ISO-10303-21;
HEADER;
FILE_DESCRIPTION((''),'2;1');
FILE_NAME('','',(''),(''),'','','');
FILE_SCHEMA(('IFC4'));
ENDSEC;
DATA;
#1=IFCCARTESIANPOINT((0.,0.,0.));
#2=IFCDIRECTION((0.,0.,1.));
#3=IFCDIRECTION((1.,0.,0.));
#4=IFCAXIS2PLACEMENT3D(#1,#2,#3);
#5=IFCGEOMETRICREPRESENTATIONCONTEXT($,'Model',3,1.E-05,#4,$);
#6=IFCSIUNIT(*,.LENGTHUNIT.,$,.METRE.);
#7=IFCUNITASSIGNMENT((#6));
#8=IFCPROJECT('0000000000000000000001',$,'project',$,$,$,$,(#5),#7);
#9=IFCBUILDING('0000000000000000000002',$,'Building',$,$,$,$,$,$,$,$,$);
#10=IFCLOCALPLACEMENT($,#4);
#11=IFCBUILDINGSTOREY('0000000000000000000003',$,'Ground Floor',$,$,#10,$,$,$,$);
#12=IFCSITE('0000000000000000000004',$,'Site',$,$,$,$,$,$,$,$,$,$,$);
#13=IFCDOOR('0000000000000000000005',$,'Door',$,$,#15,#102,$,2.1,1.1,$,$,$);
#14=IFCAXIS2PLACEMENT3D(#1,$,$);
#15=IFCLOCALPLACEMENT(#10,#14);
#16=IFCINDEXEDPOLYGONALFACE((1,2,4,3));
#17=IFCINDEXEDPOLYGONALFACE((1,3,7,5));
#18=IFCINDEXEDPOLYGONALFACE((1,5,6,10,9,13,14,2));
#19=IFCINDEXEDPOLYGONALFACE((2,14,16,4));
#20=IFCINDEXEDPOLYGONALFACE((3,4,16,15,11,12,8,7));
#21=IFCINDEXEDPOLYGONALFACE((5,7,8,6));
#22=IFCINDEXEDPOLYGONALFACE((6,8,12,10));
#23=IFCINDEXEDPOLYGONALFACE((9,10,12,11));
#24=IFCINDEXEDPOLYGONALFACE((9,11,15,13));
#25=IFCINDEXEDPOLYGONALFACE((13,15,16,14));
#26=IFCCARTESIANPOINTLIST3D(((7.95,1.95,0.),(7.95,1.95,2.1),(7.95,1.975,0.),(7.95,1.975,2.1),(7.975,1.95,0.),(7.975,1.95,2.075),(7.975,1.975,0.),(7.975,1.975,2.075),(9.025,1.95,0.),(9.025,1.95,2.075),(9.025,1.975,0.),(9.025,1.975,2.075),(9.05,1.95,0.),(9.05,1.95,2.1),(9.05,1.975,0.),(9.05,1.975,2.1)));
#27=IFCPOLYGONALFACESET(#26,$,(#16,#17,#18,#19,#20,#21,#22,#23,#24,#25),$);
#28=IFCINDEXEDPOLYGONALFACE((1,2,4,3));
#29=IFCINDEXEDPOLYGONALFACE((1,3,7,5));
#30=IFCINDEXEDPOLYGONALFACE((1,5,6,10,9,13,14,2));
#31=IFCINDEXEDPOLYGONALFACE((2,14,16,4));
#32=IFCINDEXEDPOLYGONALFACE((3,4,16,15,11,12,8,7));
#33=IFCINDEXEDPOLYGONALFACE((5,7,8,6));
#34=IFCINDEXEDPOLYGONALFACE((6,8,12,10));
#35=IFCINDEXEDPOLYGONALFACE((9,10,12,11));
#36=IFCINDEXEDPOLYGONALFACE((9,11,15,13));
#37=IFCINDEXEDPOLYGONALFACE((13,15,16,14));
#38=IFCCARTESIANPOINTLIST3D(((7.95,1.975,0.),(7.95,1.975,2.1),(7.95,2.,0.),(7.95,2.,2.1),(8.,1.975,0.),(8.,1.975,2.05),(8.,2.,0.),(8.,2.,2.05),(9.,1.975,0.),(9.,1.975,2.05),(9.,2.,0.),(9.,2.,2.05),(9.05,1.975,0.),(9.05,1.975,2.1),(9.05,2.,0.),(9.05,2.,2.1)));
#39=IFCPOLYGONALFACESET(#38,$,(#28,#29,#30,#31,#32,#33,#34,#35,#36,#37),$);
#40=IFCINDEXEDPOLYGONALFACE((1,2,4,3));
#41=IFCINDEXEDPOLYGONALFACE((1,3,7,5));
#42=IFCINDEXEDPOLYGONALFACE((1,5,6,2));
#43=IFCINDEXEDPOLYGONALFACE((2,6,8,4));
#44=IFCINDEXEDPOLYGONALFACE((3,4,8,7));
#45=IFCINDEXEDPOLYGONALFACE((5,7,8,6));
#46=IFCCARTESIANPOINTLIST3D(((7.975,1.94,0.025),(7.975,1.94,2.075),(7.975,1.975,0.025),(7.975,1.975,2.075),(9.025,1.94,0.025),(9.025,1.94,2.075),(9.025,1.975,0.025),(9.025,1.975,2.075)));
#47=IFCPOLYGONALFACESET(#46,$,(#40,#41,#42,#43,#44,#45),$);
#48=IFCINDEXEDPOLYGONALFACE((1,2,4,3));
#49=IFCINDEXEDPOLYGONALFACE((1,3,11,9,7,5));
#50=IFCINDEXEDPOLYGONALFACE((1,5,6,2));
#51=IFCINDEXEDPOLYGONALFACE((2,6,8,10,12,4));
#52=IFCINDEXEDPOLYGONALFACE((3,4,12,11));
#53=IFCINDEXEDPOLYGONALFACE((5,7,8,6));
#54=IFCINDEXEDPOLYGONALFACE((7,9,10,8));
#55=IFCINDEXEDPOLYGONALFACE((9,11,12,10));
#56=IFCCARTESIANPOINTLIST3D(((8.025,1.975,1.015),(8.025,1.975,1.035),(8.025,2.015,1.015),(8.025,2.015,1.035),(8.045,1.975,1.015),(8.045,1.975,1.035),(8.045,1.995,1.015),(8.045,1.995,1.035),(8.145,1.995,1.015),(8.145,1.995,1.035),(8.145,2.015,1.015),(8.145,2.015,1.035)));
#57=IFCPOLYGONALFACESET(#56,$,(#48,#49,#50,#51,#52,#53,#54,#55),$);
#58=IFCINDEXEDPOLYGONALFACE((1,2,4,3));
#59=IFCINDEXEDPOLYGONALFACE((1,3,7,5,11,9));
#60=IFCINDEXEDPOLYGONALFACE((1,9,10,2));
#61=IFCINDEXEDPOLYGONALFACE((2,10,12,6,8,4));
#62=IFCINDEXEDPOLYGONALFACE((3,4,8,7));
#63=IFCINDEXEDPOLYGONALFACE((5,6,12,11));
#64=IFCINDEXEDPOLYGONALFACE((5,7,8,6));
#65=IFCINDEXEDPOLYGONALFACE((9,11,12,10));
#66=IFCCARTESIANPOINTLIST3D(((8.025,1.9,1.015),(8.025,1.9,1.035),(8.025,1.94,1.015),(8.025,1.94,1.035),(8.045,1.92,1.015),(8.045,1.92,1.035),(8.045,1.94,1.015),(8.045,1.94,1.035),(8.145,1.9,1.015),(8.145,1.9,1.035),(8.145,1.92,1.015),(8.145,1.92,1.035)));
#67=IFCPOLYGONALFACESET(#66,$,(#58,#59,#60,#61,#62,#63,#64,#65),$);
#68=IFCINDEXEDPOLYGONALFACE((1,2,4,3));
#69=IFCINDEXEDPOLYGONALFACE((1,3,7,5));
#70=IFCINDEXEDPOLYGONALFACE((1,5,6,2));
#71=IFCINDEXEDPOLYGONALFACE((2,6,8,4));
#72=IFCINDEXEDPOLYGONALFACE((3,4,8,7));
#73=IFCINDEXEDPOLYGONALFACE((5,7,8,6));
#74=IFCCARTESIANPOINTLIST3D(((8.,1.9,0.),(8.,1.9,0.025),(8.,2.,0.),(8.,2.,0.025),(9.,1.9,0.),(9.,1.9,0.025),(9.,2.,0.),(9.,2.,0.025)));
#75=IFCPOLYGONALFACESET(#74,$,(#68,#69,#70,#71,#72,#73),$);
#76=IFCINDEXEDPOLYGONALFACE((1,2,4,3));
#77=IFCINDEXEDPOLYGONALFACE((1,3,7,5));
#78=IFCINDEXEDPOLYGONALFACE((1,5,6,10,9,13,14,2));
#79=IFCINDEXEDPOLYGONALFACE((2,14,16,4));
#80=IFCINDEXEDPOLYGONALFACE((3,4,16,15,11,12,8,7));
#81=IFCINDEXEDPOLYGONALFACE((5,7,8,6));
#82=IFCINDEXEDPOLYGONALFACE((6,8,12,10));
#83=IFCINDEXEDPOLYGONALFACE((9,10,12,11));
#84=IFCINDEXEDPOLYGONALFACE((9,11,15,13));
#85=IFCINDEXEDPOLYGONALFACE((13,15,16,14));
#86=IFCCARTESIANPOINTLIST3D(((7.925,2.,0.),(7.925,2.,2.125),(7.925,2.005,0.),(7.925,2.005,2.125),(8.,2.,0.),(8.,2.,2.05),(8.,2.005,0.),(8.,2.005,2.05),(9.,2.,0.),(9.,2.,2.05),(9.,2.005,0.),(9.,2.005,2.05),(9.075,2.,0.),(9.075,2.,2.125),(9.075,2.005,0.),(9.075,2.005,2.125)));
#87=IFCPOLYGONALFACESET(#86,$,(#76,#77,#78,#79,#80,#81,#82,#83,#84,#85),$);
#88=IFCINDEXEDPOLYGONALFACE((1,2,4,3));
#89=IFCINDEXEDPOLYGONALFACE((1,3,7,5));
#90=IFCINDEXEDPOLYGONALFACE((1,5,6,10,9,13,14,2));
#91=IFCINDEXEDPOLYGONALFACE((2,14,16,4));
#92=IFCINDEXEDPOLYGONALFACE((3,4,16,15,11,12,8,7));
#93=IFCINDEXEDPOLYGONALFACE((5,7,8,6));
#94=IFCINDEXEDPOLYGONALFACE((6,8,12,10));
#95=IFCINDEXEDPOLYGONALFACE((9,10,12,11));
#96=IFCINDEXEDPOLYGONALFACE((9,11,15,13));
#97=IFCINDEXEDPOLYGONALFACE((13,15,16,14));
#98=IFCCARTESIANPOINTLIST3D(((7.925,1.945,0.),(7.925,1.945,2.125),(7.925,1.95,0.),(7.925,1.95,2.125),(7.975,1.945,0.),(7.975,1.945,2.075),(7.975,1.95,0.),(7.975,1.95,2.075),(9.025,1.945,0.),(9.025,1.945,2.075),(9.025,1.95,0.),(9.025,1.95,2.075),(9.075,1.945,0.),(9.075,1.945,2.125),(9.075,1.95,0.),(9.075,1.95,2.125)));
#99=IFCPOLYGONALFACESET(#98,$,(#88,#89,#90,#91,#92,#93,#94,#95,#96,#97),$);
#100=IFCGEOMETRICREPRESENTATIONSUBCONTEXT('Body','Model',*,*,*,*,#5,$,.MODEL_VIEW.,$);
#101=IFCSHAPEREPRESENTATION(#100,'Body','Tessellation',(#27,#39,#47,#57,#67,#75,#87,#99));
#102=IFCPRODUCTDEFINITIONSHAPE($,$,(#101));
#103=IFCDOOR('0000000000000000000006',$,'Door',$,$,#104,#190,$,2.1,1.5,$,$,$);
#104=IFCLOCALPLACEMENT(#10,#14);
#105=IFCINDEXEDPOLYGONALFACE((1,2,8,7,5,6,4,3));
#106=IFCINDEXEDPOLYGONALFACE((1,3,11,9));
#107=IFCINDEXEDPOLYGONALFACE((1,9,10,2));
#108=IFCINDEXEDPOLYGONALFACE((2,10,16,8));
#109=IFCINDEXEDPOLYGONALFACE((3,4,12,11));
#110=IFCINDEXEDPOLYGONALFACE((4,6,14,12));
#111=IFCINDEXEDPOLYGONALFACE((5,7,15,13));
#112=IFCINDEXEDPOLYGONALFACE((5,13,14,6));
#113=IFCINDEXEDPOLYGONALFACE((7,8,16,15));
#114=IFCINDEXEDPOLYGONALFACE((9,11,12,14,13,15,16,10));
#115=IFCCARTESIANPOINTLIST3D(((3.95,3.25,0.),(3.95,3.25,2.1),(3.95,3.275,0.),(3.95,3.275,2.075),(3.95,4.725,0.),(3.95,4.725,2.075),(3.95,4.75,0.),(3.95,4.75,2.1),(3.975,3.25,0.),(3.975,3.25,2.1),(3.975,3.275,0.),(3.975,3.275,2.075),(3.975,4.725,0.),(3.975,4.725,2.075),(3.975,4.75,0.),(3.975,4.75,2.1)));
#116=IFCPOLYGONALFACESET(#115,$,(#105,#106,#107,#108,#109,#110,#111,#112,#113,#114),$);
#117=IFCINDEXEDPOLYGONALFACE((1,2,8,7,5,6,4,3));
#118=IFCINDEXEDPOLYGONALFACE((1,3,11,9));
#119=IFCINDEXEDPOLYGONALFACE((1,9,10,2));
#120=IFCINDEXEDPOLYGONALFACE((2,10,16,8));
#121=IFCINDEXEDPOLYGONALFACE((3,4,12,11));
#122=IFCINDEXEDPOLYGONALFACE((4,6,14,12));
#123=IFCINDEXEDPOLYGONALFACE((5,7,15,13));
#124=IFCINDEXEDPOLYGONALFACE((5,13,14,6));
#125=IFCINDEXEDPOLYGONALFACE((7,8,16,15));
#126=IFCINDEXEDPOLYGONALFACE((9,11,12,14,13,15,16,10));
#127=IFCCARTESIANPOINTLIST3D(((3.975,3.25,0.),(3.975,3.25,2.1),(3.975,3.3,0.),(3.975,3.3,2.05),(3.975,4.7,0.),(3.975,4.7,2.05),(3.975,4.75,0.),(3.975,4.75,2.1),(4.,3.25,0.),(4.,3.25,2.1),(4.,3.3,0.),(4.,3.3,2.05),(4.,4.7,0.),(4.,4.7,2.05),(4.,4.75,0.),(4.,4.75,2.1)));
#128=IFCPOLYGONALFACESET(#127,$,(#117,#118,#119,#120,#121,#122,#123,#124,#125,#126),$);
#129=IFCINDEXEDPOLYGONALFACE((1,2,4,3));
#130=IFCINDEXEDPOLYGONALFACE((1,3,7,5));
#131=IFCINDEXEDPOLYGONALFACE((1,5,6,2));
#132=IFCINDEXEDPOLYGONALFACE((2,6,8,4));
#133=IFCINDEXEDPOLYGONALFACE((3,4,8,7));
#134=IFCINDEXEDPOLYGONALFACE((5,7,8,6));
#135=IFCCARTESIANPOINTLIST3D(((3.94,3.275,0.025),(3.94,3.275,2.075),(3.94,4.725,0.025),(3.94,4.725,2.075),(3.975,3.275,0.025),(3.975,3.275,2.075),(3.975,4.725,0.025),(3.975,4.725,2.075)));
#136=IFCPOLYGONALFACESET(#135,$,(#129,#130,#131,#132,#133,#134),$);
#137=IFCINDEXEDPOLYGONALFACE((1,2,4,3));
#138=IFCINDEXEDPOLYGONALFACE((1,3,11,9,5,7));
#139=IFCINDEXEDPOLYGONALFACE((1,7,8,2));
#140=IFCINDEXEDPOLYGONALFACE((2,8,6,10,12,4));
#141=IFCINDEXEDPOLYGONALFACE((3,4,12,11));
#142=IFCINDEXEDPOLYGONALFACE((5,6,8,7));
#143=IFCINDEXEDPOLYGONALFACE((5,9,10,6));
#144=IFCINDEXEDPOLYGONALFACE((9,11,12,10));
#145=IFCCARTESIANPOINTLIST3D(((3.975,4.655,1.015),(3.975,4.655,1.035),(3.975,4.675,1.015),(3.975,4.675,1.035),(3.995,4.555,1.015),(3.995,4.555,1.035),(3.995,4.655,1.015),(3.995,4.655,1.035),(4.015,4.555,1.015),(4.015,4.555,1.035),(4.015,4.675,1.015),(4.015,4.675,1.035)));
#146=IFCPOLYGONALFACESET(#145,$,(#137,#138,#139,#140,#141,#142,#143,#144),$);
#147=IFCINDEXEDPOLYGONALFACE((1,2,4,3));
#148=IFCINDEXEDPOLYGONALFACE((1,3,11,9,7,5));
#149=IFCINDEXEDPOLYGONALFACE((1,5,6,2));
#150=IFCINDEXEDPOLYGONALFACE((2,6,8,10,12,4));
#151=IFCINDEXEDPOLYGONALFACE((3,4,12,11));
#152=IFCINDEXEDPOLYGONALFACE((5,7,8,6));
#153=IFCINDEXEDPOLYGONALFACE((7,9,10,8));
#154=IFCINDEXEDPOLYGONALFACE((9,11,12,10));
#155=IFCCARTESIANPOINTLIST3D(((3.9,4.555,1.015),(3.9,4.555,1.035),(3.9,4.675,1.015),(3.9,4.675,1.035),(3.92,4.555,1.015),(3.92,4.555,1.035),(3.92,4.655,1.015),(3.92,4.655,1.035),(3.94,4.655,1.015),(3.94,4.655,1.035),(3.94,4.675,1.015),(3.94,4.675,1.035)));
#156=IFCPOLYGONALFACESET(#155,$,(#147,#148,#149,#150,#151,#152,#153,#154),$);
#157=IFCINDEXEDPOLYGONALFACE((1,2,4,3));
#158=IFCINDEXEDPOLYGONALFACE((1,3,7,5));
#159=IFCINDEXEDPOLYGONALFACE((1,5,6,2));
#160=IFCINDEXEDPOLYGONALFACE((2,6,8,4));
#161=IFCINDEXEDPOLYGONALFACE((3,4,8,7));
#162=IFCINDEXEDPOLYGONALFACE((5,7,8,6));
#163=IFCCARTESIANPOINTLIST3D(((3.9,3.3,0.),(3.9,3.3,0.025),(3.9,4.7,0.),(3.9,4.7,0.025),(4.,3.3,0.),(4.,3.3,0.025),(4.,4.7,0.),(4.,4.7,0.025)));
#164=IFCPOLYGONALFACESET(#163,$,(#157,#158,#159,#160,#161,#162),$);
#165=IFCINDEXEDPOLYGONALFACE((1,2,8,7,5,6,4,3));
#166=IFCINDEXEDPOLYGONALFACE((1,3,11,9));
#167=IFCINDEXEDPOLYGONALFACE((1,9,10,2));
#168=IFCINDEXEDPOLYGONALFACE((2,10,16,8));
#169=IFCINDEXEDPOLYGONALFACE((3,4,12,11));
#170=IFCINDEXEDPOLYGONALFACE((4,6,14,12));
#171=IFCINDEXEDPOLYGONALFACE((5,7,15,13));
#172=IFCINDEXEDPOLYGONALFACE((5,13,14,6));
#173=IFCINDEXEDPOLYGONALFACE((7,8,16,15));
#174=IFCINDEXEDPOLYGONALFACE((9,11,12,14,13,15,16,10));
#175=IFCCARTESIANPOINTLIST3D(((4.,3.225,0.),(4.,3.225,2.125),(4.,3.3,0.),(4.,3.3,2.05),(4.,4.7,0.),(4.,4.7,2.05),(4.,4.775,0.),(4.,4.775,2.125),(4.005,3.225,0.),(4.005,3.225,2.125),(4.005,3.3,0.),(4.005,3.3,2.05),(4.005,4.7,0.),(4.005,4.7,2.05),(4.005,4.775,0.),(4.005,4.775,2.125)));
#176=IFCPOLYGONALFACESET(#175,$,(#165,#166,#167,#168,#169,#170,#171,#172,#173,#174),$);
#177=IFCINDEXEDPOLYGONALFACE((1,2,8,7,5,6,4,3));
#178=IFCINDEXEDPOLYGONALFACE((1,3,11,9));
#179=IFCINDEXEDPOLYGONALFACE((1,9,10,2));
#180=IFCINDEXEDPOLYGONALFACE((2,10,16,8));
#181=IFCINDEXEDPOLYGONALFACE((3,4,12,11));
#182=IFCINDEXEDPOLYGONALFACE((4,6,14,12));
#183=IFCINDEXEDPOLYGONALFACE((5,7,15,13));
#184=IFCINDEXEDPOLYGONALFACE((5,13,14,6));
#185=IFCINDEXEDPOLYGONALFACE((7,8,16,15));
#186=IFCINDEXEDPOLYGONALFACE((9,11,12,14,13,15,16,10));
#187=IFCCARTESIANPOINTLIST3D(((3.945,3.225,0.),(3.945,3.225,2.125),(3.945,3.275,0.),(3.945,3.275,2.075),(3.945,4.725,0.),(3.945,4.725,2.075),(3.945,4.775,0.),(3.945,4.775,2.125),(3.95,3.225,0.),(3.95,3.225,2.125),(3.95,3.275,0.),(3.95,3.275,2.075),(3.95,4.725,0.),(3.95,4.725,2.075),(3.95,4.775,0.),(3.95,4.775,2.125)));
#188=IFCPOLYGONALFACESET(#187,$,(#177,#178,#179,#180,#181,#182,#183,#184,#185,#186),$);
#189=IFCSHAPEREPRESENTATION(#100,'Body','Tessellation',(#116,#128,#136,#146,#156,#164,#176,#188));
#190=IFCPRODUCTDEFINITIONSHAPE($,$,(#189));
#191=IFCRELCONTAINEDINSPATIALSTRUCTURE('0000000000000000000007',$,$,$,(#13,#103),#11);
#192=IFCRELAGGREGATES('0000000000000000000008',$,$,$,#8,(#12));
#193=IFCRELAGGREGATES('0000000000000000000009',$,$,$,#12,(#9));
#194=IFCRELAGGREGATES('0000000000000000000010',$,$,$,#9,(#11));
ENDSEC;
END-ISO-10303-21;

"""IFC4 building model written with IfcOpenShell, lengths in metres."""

from ifc_helpers import new_model, si_unit, frame, origin_with_axes, place, context, subcontext, project, spatial, line, indexed_curve, outline, extrude, element, save


model = new_model("IFC4")

# Units and contexts
model_context = context("Model", 3, precision=1e-05, world=origin_with_axes())
body_context = subcontext(model_context, "Body", "Model", "MODEL_VIEW")
ifc_project = project(units=[si_unit("LENGTHUNIT", "METRE")], contexts=[model_context])

# Site, building, storey
site = spatial("IfcSite", under=ifc_project, Name="Site")
building = spatial("IfcBuilding", under=site, Name="Building")
storey_placement = place(None, origin_with_axes())
storey = spatial("IfcBuildingStorey", under=building, at=storey_placement, Name="Ground Floor")

# Doors
door_1_placement = place(storey_placement, frame((9.05, 2.0, 0.0), z_axis=(0.0, 0.0, 1.0), x_axis=(-1.0, 0.0, 0.0)))
element("IfcDoor", 1, at=door_1_placement, inside=storey, Name="Door", OverallHeight=2.1, OverallWidth=1.1, context=body_context, shape_type="SweptSolid", body=[
    extrude(outline(indexed_curve([(0.0, 0.0), (0.0, 2.1), (1.1, 2.1), (1.1, 0.0), (1.075, 0.0), (1.075, 2.075), (0.025, 2.075), (0.025, 0.0)], segments=[line(1, 2, 3, 4, 5, 6, 7, 8, 1)])), frame((0.0, 0.025, 0.0), z_axis=(0.0, -1.0, 0.0), x_axis=(1.0, 0.0, 0.0)), (0.0, 0.0, -1.0), 0.025),
    extrude(outline(indexed_curve([(0.0, 0.0), (0.0, 2.1), (1.1, 2.1), (1.1, 0.0), (1.05, 0.0), (1.05, 2.05), (0.05, 2.05), (0.05, 0.0)], segments=[line(1, 2, 3, 4, 5, 6, 7, 8, 1)])), frame((0.0, 0.0, 0.0), z_axis=(0.0, -1.0, 0.0), x_axis=(1.0, 0.0, 0.0)), (0.0, 0.0, -1.0), 0.025),
    extrude(outline(indexed_curve([(0.0, 0.0), (1.05, 0.0), (1.05, 0.035), (0.0, 0.035)], segments=[line(1, 2, 3, 4, 1)])), frame((0.025, 0.025, 0.025), z_axis=(0.0, 0.0, 1.0), x_axis=(1.0, 0.0, 0.0)), (0.0, 0.0, 1.0), 2.05),
    extrude(outline(indexed_curve([(0.0, 0.0), (0.0, -0.04), (-0.12, -0.04), (-0.12, -0.02), (-0.02, -0.02), (-0.02, 0.0)], segments=[line(1, 2, 3, 4, 5, 6, 1)])), frame((1.025, 0.025, 1.015), z_axis=(0.0, 0.0, 1.0), x_axis=(1.0, 0.0, 0.0)), (0.0, 0.0, 1.0), 0.02),
    extrude(outline(indexed_curve([(0.0, 0.0), (0.0, 0.04), (-0.12, 0.04), (-0.12, 0.02), (-0.02, 0.02), (-0.02, 0.0)], segments=[line(1, 2, 3, 4, 5, 6, 1)])), frame((1.025, 0.06, 1.015), z_axis=(0.0, 0.0, 1.0), x_axis=(1.0, 0.0, 0.0)), (0.0, 0.0, 1.0), 0.02),
    extrude(outline(indexed_curve([(0.0, 0.0), (1.0, 0.0), (1.0, 0.1), (0.0, 0.1)], segments=[line(1, 2, 3, 4, 1)])), frame((0.05, 0.0, 0.0), z_axis=(0.0, 0.0, 1.0), x_axis=(1.0, 0.0, 0.0)), (0.0, 0.0, 1.0), 0.025),
    extrude(outline(indexed_curve([(0.0, 0.0), (0.0, 2.125), (1.15, 2.125), (1.15, 0.0), (1.075, 0.0), (1.075, 2.05), (0.075, 2.05), (0.075, 0.0)], segments=[line(1, 2, 3, 4, 5, 6, 7, 8, 1)])), frame((-0.025, -0.005, 0.0), z_axis=(0.0, -1.0, 0.0), x_axis=(1.0, 0.0, 0.0)), (0.0, 0.0, -1.0), 0.005),
    extrude(outline(indexed_curve([(0.0, 0.0), (0.0, 2.125), (1.15, 2.125), (1.15, 0.0), (1.1, 0.0), (1.1, 2.075), (0.05, 2.075), (0.05, 0.0)], segments=[line(1, 2, 3, 4, 5, 6, 7, 8, 1)])), frame((-0.025, 0.05, 0.0), z_axis=(0.0, -1.0, 0.0), x_axis=(1.0, 0.0, 0.0)), (0.0, 0.0, -1.0), 0.005),
])
door_2_placement = place(storey_placement, frame((4.0, 3.25, 0.0), z_axis=(0.0, 0.0, 1.0), x_axis=(0.0, 1.0, 0.0)))
element("IfcDoor", 2, at=door_2_placement, inside=storey, Name="Door", OverallHeight=2.1, OverallWidth=1.5, context=body_context, shape_type="SweptSolid", body=[
    extrude(outline(indexed_curve([(0.0, 0.0), (0.0, 2.1), (1.5, 2.1), (1.5, 0.0), (1.475, 0.0), (1.475, 2.075), (0.025, 2.075), (0.025, 0.0)], segments=[line(1, 2, 3, 4, 5, 6, 7, 8, 1)])), frame((0.0, 0.025, 0.0), z_axis=(0.0, -1.0, 0.0), x_axis=(1.0, 0.0, 0.0)), (0.0, 0.0, -1.0), 0.025),
    extrude(outline(indexed_curve([(0.0, 0.0), (0.0, 2.1), (1.5, 2.1), (1.5, 0.0), (1.45, 0.0), (1.45, 2.05), (0.05, 2.05), (0.05, 0.0)], segments=[line(1, 2, 3, 4, 5, 6, 7, 8, 1)])), frame((0.0, 0.0, 0.0), z_axis=(0.0, -1.0, 0.0), x_axis=(1.0, 0.0, 0.0)), (0.0, 0.0, -1.0), 0.025),
    extrude(outline(indexed_curve([(0.0, 0.0), (1.45, 0.0), (1.45, 0.035), (0.0, 0.035)], segments=[line(1, 2, 3, 4, 1)])), frame((0.025, 0.025, 0.025), z_axis=(0.0, 0.0, 1.0), x_axis=(1.0, 0.0, 0.0)), (0.0, 0.0, 1.0), 2.05),
    extrude(outline(indexed_curve([(0.0, 0.0), (0.0, -0.04), (-0.12, -0.04), (-0.12, -0.02), (-0.02, -0.02), (-0.02, 0.0)], segments=[line(1, 2, 3, 4, 5, 6, 1)])), frame((1.425, 0.025, 1.015), z_axis=(0.0, 0.0, 1.0), x_axis=(1.0, 0.0, 0.0)), (0.0, 0.0, 1.0), 0.02),
    extrude(outline(indexed_curve([(0.0, 0.0), (0.0, 0.04), (-0.12, 0.04), (-0.12, 0.02), (-0.02, 0.02), (-0.02, 0.0)], segments=[line(1, 2, 3, 4, 5, 6, 1)])), frame((1.425, 0.06, 1.015), z_axis=(0.0, 0.0, 1.0), x_axis=(1.0, 0.0, 0.0)), (0.0, 0.0, 1.0), 0.02),
    extrude(outline(indexed_curve([(0.0, 0.0), (1.4, 0.0), (1.4, 0.1), (0.0, 0.1)], segments=[line(1, 2, 3, 4, 1)])), frame((0.05, 0.0, 0.0), z_axis=(0.0, 0.0, 1.0), x_axis=(1.0, 0.0, 0.0)), (0.0, 0.0, 1.0), 0.025),
    extrude(outline(indexed_curve([(0.0, 0.0), (0.0, 2.125), (1.55, 2.125), (1.55, 0.0), (1.475, 0.0), (1.475, 2.05), (0.075, 2.05), (0.075, 0.0)], segments=[line(1, 2, 3, 4, 5, 6, 7, 8, 1)])), frame((-0.025, -0.005, 0.0), z_axis=(0.0, -1.0, 0.0), x_axis=(1.0, 0.0, 0.0)), (0.0, 0.0, -1.0), 0.005),
    extrude(outline(indexed_curve([(0.0, 0.0), (0.0, 2.125), (1.55, 2.125), (1.55, 0.0), (1.5, 0.0), (1.5, 2.075), (0.05, 2.075), (0.05, 0.0)], segments=[line(1, 2, 3, 4, 5, 6, 7, 8, 1)])), frame((-0.025, 0.05, 0.0), z_axis=(0.0, -1.0, 0.0), x_axis=(1.0, 0.0, 0.0)), (0.0, 0.0, -1.0), 0.005),
])

save(model, "model.ifc")
